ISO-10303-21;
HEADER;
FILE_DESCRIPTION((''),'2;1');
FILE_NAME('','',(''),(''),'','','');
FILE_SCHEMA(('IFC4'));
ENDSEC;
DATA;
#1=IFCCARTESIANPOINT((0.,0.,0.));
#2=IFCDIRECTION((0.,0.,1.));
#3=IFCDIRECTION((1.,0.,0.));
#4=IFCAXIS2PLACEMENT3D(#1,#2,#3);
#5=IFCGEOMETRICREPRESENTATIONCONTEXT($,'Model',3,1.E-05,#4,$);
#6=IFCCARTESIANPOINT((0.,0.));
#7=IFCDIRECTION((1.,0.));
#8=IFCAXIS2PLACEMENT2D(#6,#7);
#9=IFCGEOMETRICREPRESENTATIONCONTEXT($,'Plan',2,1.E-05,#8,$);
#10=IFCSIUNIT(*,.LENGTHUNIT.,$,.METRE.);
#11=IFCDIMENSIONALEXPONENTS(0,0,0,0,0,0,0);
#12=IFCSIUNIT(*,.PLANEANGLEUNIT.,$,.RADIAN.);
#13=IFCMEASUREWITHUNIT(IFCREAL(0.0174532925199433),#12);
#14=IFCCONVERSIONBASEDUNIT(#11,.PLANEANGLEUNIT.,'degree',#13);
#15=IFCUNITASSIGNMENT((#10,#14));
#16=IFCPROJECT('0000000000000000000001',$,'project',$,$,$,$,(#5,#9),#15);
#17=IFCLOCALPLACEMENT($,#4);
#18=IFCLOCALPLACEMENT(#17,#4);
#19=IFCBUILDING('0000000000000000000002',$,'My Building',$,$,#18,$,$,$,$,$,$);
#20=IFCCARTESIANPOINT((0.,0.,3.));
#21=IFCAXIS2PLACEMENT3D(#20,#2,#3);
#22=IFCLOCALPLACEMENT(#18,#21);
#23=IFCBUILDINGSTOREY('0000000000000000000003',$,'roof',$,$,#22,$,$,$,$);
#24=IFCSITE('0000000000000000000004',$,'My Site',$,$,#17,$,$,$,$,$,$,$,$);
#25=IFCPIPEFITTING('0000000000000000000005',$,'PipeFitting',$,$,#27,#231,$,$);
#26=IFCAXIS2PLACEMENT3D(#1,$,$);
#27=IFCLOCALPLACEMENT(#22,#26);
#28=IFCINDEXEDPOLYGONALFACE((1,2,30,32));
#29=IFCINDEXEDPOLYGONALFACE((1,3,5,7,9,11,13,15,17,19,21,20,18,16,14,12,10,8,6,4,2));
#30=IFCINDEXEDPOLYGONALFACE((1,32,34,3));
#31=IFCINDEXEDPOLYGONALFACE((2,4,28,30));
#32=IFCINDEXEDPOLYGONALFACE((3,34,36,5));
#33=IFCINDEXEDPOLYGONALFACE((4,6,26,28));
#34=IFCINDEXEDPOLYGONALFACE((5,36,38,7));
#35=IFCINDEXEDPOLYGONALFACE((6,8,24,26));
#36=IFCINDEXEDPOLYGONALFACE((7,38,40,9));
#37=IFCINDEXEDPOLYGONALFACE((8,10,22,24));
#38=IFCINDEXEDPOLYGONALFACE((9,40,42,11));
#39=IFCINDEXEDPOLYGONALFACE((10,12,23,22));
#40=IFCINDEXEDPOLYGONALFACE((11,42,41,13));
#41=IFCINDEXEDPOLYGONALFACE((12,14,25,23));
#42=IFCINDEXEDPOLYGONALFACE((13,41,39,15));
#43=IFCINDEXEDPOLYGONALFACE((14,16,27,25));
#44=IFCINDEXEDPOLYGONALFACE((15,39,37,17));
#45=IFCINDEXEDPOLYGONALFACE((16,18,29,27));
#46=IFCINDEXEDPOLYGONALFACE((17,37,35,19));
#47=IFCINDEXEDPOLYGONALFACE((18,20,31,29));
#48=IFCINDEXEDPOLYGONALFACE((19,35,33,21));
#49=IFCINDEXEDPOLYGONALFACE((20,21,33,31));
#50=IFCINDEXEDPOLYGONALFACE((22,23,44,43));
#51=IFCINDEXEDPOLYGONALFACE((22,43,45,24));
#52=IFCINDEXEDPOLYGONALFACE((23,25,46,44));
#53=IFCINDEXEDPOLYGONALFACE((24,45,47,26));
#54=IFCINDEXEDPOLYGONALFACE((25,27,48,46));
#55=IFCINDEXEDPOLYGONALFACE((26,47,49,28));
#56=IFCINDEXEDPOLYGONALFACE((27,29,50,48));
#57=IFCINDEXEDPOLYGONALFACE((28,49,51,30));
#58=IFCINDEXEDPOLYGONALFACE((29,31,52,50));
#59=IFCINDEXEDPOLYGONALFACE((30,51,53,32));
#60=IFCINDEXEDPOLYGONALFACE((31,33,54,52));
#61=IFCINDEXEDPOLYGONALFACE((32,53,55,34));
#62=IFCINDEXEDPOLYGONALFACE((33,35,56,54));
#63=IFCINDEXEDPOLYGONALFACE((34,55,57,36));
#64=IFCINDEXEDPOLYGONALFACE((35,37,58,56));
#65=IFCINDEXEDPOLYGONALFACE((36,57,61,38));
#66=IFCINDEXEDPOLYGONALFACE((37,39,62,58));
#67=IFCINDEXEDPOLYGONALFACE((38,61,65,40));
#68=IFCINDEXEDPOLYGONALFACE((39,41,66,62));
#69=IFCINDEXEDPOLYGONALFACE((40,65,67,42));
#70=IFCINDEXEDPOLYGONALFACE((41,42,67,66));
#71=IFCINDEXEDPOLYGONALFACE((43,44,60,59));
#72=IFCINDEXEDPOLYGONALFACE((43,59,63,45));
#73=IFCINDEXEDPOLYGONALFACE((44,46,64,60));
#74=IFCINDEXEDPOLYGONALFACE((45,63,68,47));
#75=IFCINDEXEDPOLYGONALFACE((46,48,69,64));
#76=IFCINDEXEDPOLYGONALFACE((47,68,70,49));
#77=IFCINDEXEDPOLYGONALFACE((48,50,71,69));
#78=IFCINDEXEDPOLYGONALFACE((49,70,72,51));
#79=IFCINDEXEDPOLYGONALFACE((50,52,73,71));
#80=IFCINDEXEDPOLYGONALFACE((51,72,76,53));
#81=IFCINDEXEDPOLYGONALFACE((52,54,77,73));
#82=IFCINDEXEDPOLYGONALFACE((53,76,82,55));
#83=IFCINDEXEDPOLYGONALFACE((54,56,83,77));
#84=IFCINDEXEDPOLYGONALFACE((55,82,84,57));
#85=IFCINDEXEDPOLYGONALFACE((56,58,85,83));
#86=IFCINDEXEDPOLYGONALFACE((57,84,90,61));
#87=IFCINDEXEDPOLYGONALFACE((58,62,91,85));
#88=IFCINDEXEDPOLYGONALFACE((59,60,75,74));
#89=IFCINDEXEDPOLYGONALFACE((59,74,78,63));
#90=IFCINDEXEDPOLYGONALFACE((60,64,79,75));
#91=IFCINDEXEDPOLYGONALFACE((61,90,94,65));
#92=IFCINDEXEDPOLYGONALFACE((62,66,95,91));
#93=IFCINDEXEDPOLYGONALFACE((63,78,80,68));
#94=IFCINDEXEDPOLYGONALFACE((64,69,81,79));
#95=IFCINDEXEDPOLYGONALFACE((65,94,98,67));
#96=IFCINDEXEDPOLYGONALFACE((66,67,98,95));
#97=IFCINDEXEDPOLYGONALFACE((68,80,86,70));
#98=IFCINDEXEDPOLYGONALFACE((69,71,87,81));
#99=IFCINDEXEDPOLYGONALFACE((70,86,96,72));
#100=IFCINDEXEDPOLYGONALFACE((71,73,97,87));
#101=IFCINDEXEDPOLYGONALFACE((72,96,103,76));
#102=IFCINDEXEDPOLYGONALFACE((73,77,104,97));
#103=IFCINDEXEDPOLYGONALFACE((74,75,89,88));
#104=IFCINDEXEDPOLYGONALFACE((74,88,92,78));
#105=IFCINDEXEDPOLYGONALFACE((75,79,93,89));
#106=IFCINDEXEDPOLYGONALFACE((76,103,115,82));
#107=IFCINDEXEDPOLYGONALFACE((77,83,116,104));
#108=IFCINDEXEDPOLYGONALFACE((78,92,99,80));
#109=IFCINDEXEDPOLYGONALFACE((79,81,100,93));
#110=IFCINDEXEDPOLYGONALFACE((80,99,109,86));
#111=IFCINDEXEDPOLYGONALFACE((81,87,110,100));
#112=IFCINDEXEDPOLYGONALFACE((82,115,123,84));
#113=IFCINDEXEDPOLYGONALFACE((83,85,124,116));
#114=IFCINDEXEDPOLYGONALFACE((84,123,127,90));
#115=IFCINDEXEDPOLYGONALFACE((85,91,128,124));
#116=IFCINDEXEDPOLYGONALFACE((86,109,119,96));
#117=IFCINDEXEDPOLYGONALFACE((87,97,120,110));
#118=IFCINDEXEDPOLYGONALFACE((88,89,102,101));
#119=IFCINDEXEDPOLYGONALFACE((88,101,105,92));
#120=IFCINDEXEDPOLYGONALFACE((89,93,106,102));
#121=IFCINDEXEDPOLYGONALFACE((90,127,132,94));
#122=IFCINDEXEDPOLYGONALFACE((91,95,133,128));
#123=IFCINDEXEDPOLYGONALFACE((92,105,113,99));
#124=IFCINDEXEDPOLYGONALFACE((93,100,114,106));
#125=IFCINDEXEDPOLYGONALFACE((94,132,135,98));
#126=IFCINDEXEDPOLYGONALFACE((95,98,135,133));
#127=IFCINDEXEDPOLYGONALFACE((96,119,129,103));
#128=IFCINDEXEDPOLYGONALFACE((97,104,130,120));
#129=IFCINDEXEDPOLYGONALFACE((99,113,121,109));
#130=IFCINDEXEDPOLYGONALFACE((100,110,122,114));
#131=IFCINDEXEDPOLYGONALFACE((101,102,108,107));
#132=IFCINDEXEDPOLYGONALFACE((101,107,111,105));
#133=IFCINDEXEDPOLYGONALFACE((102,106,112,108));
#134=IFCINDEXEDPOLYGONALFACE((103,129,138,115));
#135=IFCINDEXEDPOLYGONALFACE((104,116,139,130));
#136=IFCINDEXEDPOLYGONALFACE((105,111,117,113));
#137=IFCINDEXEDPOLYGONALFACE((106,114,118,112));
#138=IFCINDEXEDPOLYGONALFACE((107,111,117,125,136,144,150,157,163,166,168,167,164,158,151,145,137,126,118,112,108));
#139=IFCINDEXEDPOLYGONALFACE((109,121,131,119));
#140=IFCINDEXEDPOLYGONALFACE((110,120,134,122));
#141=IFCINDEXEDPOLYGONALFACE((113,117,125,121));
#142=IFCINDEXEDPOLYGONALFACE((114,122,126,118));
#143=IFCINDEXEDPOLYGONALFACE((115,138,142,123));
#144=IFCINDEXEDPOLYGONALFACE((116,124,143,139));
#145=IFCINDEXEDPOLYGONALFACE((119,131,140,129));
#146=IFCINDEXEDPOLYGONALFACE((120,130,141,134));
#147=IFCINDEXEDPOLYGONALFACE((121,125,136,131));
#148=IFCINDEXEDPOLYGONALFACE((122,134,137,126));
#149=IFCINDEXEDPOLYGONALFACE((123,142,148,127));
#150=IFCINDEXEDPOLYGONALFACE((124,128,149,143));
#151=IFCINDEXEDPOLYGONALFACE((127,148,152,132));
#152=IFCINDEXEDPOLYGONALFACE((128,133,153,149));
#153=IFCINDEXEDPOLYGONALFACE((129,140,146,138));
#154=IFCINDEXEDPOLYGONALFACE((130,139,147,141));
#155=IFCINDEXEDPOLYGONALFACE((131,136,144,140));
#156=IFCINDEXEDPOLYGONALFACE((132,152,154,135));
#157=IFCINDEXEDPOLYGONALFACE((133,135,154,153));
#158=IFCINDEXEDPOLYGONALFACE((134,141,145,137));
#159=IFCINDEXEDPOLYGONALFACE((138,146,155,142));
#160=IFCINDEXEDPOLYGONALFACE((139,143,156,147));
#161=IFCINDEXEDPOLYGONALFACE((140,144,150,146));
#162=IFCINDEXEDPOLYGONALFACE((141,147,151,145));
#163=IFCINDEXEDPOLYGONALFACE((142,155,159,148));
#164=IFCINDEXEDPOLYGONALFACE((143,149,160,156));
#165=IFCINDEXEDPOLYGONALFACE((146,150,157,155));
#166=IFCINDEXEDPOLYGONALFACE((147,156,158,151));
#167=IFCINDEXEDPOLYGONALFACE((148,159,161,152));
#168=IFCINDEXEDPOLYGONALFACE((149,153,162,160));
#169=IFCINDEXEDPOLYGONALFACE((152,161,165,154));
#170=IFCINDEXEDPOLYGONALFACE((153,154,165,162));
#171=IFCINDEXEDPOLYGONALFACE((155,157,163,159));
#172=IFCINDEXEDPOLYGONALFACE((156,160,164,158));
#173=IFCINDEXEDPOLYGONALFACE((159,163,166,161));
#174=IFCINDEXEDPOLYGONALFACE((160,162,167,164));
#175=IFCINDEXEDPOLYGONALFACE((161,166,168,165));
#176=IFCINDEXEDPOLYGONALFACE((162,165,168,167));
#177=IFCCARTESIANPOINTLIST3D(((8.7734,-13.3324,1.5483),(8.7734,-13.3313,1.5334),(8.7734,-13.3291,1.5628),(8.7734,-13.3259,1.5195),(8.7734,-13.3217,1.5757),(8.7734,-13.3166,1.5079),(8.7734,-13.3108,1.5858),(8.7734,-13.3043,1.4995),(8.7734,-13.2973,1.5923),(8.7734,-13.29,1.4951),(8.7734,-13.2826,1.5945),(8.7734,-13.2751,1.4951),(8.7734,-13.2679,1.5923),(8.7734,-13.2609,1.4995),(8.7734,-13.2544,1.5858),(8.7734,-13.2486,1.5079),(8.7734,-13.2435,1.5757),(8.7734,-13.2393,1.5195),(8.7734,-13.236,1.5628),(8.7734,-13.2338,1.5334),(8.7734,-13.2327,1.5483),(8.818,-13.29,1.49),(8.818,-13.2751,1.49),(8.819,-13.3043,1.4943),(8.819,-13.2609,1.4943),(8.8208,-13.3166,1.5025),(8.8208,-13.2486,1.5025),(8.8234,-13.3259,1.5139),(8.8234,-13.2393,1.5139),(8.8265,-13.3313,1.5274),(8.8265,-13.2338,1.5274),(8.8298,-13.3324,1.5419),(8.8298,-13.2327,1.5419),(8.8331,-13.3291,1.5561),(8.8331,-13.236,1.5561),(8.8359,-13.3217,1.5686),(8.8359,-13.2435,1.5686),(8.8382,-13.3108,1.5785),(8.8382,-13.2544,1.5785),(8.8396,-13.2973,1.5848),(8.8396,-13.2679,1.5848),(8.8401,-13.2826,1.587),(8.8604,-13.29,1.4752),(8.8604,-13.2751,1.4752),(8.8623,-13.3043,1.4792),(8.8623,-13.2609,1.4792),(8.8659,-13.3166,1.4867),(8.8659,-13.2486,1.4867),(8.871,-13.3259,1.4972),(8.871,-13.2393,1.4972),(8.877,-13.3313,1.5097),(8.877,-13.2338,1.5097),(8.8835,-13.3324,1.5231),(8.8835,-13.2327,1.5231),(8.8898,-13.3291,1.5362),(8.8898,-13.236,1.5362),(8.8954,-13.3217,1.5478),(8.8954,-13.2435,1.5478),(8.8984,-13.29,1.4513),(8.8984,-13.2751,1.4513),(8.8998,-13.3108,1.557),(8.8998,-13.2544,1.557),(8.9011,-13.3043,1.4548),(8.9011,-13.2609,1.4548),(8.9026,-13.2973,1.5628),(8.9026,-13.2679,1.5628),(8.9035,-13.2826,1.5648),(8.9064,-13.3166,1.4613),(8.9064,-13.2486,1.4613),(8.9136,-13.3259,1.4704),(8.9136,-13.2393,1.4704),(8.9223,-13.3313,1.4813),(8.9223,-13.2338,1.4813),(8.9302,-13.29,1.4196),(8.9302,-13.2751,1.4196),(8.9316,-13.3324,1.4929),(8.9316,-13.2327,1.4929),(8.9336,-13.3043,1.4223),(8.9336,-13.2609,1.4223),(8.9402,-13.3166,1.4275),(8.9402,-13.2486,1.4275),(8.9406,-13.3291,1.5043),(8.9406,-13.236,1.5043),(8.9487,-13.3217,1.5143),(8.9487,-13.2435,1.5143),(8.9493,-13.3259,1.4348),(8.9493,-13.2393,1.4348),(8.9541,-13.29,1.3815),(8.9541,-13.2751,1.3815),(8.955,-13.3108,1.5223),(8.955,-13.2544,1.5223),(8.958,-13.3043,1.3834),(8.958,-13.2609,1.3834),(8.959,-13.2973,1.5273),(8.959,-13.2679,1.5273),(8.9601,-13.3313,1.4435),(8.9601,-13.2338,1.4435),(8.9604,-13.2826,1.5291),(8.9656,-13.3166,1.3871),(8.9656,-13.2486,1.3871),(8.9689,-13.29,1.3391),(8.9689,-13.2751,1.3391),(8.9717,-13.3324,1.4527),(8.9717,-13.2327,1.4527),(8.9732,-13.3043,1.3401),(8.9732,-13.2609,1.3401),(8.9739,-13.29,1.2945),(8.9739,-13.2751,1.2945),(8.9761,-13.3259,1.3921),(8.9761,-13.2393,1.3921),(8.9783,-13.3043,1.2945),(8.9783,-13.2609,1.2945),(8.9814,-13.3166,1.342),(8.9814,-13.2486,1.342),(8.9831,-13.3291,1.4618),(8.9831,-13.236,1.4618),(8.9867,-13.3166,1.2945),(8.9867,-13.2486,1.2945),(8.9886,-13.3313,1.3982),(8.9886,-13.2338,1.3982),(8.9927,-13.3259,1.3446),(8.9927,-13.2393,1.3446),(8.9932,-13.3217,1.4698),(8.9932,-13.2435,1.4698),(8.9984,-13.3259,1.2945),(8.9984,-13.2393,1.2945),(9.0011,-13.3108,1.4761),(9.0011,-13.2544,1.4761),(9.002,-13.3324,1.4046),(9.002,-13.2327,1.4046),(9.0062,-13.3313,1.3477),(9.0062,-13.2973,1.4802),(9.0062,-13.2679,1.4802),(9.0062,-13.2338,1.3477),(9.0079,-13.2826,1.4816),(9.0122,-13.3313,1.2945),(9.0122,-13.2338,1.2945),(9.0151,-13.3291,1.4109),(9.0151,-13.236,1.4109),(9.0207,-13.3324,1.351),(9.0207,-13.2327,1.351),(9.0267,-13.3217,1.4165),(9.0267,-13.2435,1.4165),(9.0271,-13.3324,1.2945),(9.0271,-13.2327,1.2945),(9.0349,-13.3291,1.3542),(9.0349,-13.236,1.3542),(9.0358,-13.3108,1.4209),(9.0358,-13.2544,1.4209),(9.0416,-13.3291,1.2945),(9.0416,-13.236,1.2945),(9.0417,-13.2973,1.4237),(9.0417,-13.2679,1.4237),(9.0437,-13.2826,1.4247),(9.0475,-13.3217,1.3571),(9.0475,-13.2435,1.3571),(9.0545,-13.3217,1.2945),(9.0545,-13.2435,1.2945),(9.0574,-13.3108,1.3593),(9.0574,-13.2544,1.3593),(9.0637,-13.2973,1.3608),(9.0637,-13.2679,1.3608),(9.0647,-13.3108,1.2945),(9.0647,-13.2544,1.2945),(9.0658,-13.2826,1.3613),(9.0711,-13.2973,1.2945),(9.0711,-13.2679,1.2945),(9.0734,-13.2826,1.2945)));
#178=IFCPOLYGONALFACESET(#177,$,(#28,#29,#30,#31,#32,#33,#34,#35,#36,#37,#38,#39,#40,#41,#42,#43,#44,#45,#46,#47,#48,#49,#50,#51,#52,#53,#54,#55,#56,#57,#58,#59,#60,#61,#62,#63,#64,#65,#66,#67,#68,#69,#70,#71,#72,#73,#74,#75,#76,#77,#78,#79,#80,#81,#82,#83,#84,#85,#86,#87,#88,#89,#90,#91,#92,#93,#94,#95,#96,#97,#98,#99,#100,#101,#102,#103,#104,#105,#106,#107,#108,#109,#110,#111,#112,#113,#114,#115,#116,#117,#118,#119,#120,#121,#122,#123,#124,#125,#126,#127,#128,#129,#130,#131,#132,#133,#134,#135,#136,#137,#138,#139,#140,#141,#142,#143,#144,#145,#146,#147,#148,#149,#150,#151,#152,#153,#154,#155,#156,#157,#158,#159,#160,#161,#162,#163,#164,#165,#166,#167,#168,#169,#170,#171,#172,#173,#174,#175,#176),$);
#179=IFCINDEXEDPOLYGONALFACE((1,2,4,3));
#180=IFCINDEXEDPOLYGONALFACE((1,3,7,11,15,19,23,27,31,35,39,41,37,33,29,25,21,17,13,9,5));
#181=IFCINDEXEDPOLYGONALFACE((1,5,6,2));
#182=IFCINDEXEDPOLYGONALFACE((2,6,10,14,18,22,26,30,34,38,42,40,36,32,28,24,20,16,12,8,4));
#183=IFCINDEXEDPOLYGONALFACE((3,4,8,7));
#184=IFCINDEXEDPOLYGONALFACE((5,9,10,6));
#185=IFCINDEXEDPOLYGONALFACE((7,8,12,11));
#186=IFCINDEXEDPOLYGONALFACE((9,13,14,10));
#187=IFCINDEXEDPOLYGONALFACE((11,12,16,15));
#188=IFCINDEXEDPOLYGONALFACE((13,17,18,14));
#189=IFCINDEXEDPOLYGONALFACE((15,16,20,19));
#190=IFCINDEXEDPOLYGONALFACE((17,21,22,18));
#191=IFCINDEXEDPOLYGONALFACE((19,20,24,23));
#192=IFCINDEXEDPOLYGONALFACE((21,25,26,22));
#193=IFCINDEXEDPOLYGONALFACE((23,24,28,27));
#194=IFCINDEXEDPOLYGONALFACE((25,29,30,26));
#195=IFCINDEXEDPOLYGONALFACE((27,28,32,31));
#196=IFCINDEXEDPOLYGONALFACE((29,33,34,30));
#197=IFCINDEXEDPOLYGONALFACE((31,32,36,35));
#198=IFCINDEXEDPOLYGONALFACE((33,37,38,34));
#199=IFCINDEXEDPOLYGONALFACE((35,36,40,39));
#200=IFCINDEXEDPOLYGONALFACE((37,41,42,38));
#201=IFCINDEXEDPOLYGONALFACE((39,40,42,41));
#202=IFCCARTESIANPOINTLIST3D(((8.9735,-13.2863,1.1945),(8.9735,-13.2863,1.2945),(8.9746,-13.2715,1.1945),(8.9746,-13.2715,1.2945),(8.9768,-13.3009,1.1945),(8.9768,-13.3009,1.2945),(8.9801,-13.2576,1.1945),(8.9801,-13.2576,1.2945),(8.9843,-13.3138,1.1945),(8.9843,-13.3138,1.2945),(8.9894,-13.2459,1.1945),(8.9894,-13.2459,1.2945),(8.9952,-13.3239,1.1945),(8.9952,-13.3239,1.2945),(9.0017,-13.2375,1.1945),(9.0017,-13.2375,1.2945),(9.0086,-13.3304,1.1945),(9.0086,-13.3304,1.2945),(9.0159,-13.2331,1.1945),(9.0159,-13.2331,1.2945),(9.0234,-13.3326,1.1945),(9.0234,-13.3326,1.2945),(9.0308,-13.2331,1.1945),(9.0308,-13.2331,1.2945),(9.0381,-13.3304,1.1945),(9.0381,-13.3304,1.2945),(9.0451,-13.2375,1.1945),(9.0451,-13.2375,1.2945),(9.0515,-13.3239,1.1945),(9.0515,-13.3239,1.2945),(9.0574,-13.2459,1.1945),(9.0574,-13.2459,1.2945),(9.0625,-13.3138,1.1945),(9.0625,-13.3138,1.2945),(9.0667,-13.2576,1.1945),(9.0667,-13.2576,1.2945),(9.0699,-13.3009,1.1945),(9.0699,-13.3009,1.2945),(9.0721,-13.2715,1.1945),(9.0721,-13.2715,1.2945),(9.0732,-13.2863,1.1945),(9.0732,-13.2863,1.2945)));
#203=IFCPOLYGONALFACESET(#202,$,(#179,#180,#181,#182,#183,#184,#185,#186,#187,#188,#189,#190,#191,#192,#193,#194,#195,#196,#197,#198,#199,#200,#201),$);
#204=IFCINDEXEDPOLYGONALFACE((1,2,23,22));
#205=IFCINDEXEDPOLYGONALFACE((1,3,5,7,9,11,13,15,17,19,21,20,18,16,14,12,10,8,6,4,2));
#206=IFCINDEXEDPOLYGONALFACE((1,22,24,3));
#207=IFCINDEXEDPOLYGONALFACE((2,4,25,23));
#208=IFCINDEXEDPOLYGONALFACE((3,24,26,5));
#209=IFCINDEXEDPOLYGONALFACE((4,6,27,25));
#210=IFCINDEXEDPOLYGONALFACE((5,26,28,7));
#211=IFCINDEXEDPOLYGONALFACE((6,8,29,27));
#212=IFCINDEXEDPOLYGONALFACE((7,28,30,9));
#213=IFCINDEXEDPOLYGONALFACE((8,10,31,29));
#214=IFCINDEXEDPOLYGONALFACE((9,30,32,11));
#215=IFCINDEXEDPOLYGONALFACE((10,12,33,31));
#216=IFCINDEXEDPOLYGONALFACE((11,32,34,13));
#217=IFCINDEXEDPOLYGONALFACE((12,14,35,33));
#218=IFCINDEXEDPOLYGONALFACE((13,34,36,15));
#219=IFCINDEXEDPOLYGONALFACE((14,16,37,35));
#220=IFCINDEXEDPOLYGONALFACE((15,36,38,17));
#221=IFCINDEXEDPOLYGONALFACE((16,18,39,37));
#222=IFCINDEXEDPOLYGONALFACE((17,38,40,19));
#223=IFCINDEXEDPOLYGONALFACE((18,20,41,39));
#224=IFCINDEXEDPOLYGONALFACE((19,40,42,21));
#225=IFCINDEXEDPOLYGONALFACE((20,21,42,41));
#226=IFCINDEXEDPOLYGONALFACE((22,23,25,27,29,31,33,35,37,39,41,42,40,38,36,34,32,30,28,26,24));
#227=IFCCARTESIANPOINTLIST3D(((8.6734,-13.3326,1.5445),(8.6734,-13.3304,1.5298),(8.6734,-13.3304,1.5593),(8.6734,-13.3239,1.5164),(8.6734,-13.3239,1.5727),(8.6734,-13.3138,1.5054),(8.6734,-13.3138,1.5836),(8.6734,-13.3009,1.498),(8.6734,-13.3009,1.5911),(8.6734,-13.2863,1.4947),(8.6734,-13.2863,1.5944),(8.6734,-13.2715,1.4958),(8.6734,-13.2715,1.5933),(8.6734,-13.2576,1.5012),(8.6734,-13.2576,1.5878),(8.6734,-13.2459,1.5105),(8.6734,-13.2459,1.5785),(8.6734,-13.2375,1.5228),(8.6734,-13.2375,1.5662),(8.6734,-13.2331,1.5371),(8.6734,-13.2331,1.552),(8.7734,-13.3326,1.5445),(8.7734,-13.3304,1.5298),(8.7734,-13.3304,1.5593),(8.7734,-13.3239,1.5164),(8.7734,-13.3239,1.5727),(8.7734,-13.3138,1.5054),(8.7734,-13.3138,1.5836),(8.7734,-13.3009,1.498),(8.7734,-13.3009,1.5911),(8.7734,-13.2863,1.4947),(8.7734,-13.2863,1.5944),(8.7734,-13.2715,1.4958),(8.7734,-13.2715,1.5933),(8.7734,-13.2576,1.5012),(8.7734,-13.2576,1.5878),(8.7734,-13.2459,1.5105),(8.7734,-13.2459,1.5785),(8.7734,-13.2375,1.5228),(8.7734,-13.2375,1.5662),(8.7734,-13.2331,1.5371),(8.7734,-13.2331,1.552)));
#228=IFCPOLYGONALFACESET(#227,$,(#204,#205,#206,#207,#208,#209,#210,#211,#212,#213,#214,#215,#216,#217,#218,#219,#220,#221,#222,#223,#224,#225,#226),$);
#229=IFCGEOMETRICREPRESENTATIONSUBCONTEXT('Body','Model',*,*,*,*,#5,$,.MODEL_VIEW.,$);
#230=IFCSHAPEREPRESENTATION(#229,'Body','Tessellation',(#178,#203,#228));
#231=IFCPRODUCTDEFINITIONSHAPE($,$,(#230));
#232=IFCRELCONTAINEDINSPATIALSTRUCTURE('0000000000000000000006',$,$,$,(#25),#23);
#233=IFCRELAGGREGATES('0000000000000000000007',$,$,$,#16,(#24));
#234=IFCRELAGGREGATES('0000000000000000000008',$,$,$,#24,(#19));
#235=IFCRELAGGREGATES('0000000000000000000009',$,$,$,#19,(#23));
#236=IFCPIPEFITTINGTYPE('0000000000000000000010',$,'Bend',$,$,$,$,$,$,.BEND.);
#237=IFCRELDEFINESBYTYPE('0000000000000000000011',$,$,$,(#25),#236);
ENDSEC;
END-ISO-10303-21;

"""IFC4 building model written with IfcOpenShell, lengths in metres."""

from ifc_helpers import new_model, entity, si_unit, converted_unit, frame, origin_with_axes, origin_2d_with_axis, place, context, subcontext, project, spatial, circle, extrude, source, transform, mapped, type_object, type_shapes, element, save


model = new_model("IFC4")

# Units and contexts
model_context = context("Model", 3, precision=1e-05, world=origin_with_axes())
plan_context = context("Plan", 2, precision=1e-05, world=origin_2d_with_axis())
body_context_1 = subcontext(model_context, "Body", "Model", "MODEL_VIEW")
ifc_project = project(units=[si_unit("LENGTHUNIT", "METRE"), converted_unit("PLANEANGLEUNIT", "degree", entity("IfcReal", 0.0174532925199433), si_unit("PLANEANGLEUNIT", "RADIAN"), dimensions=[0, 0, 0, 0, 0, 0, 0])], contexts=[model_context, plan_context])

# Site, building, storey
site_placement = place(None, origin_with_axes())
site = spatial("IfcSite", under=ifc_project, at=site_placement, Name="My Site")
building_placement = place(site_placement, origin_with_axes())
building = spatial("IfcBuilding", under=site, at=building_placement, Name="My Building")
storey_placement = place(building_placement, frame((0.0, 0.0, 3.0), z_axis=(0.0, 0.0, 1.0), x_axis=(1.0, 0.0, 0.0)))
storey = spatial("IfcBuildingStorey", under=building, at=storey_placement, Name="roof")

# Pipe fitting
pipe_fitting_type_1 = type_object("IfcPipeFittingType", Name="Bend", PredefinedType="BEND")
shared_shape_1 = source(origin_with_axes(), body_context_1, "Body", "SolidModel", [
    entity("IfcSweptDiskSolid", entity("IfcIndexedPolyCurve", entity("IfcCartesianPointList3D", [[0.0, 0.0, 0.1], [0.0, -0.0732, 0.2768], [0.0, -0.25, 0.35]]), [entity("IfcArcIndex", [1, 2, 3])]), 0.05),
    extrude(circle(Radius=0.05), origin_with_axes(), (0.0, 0.0, 1.0), 0.1),
    extrude(circle(Radius=0.05), frame((0.0, -0.25, 0.35), z_axis=(0.0, -1.0, 0.0), x_axis=(1.0, 0.0, 0.0)), (0.0, 0.0, 1.0), 0.1),
])
type_shapes(pipe_fitting_type_1, [shared_shape_1])
for number, where, z_axis, x_axis, name in (
    (1, (9.0234, -13.2826, 1.1945), (0.000001, -0.000001, 1.0), (0.0, -1.0, -0.000001), "PipeFitting"),
):
    element("IfcPipeFitting", number, at=place(storey_placement, frame(where, z_axis=z_axis, x_axis=x_axis)), inside=storey, type_object=pipe_fitting_type_1, Name=name, context=body_context_1, shape_type="MappedRepresentation", body=[
        mapped(shared_shape_1, transform((0.0, 0.0, 0.0), x_axis=(1.0, 0.0, 0.0), y_axis=(0.0, 1.0, 0.0), z_axis=(0.0, 0.0, 1.0), scale=1.0)),
    ])

save(model, "model.ifc")
